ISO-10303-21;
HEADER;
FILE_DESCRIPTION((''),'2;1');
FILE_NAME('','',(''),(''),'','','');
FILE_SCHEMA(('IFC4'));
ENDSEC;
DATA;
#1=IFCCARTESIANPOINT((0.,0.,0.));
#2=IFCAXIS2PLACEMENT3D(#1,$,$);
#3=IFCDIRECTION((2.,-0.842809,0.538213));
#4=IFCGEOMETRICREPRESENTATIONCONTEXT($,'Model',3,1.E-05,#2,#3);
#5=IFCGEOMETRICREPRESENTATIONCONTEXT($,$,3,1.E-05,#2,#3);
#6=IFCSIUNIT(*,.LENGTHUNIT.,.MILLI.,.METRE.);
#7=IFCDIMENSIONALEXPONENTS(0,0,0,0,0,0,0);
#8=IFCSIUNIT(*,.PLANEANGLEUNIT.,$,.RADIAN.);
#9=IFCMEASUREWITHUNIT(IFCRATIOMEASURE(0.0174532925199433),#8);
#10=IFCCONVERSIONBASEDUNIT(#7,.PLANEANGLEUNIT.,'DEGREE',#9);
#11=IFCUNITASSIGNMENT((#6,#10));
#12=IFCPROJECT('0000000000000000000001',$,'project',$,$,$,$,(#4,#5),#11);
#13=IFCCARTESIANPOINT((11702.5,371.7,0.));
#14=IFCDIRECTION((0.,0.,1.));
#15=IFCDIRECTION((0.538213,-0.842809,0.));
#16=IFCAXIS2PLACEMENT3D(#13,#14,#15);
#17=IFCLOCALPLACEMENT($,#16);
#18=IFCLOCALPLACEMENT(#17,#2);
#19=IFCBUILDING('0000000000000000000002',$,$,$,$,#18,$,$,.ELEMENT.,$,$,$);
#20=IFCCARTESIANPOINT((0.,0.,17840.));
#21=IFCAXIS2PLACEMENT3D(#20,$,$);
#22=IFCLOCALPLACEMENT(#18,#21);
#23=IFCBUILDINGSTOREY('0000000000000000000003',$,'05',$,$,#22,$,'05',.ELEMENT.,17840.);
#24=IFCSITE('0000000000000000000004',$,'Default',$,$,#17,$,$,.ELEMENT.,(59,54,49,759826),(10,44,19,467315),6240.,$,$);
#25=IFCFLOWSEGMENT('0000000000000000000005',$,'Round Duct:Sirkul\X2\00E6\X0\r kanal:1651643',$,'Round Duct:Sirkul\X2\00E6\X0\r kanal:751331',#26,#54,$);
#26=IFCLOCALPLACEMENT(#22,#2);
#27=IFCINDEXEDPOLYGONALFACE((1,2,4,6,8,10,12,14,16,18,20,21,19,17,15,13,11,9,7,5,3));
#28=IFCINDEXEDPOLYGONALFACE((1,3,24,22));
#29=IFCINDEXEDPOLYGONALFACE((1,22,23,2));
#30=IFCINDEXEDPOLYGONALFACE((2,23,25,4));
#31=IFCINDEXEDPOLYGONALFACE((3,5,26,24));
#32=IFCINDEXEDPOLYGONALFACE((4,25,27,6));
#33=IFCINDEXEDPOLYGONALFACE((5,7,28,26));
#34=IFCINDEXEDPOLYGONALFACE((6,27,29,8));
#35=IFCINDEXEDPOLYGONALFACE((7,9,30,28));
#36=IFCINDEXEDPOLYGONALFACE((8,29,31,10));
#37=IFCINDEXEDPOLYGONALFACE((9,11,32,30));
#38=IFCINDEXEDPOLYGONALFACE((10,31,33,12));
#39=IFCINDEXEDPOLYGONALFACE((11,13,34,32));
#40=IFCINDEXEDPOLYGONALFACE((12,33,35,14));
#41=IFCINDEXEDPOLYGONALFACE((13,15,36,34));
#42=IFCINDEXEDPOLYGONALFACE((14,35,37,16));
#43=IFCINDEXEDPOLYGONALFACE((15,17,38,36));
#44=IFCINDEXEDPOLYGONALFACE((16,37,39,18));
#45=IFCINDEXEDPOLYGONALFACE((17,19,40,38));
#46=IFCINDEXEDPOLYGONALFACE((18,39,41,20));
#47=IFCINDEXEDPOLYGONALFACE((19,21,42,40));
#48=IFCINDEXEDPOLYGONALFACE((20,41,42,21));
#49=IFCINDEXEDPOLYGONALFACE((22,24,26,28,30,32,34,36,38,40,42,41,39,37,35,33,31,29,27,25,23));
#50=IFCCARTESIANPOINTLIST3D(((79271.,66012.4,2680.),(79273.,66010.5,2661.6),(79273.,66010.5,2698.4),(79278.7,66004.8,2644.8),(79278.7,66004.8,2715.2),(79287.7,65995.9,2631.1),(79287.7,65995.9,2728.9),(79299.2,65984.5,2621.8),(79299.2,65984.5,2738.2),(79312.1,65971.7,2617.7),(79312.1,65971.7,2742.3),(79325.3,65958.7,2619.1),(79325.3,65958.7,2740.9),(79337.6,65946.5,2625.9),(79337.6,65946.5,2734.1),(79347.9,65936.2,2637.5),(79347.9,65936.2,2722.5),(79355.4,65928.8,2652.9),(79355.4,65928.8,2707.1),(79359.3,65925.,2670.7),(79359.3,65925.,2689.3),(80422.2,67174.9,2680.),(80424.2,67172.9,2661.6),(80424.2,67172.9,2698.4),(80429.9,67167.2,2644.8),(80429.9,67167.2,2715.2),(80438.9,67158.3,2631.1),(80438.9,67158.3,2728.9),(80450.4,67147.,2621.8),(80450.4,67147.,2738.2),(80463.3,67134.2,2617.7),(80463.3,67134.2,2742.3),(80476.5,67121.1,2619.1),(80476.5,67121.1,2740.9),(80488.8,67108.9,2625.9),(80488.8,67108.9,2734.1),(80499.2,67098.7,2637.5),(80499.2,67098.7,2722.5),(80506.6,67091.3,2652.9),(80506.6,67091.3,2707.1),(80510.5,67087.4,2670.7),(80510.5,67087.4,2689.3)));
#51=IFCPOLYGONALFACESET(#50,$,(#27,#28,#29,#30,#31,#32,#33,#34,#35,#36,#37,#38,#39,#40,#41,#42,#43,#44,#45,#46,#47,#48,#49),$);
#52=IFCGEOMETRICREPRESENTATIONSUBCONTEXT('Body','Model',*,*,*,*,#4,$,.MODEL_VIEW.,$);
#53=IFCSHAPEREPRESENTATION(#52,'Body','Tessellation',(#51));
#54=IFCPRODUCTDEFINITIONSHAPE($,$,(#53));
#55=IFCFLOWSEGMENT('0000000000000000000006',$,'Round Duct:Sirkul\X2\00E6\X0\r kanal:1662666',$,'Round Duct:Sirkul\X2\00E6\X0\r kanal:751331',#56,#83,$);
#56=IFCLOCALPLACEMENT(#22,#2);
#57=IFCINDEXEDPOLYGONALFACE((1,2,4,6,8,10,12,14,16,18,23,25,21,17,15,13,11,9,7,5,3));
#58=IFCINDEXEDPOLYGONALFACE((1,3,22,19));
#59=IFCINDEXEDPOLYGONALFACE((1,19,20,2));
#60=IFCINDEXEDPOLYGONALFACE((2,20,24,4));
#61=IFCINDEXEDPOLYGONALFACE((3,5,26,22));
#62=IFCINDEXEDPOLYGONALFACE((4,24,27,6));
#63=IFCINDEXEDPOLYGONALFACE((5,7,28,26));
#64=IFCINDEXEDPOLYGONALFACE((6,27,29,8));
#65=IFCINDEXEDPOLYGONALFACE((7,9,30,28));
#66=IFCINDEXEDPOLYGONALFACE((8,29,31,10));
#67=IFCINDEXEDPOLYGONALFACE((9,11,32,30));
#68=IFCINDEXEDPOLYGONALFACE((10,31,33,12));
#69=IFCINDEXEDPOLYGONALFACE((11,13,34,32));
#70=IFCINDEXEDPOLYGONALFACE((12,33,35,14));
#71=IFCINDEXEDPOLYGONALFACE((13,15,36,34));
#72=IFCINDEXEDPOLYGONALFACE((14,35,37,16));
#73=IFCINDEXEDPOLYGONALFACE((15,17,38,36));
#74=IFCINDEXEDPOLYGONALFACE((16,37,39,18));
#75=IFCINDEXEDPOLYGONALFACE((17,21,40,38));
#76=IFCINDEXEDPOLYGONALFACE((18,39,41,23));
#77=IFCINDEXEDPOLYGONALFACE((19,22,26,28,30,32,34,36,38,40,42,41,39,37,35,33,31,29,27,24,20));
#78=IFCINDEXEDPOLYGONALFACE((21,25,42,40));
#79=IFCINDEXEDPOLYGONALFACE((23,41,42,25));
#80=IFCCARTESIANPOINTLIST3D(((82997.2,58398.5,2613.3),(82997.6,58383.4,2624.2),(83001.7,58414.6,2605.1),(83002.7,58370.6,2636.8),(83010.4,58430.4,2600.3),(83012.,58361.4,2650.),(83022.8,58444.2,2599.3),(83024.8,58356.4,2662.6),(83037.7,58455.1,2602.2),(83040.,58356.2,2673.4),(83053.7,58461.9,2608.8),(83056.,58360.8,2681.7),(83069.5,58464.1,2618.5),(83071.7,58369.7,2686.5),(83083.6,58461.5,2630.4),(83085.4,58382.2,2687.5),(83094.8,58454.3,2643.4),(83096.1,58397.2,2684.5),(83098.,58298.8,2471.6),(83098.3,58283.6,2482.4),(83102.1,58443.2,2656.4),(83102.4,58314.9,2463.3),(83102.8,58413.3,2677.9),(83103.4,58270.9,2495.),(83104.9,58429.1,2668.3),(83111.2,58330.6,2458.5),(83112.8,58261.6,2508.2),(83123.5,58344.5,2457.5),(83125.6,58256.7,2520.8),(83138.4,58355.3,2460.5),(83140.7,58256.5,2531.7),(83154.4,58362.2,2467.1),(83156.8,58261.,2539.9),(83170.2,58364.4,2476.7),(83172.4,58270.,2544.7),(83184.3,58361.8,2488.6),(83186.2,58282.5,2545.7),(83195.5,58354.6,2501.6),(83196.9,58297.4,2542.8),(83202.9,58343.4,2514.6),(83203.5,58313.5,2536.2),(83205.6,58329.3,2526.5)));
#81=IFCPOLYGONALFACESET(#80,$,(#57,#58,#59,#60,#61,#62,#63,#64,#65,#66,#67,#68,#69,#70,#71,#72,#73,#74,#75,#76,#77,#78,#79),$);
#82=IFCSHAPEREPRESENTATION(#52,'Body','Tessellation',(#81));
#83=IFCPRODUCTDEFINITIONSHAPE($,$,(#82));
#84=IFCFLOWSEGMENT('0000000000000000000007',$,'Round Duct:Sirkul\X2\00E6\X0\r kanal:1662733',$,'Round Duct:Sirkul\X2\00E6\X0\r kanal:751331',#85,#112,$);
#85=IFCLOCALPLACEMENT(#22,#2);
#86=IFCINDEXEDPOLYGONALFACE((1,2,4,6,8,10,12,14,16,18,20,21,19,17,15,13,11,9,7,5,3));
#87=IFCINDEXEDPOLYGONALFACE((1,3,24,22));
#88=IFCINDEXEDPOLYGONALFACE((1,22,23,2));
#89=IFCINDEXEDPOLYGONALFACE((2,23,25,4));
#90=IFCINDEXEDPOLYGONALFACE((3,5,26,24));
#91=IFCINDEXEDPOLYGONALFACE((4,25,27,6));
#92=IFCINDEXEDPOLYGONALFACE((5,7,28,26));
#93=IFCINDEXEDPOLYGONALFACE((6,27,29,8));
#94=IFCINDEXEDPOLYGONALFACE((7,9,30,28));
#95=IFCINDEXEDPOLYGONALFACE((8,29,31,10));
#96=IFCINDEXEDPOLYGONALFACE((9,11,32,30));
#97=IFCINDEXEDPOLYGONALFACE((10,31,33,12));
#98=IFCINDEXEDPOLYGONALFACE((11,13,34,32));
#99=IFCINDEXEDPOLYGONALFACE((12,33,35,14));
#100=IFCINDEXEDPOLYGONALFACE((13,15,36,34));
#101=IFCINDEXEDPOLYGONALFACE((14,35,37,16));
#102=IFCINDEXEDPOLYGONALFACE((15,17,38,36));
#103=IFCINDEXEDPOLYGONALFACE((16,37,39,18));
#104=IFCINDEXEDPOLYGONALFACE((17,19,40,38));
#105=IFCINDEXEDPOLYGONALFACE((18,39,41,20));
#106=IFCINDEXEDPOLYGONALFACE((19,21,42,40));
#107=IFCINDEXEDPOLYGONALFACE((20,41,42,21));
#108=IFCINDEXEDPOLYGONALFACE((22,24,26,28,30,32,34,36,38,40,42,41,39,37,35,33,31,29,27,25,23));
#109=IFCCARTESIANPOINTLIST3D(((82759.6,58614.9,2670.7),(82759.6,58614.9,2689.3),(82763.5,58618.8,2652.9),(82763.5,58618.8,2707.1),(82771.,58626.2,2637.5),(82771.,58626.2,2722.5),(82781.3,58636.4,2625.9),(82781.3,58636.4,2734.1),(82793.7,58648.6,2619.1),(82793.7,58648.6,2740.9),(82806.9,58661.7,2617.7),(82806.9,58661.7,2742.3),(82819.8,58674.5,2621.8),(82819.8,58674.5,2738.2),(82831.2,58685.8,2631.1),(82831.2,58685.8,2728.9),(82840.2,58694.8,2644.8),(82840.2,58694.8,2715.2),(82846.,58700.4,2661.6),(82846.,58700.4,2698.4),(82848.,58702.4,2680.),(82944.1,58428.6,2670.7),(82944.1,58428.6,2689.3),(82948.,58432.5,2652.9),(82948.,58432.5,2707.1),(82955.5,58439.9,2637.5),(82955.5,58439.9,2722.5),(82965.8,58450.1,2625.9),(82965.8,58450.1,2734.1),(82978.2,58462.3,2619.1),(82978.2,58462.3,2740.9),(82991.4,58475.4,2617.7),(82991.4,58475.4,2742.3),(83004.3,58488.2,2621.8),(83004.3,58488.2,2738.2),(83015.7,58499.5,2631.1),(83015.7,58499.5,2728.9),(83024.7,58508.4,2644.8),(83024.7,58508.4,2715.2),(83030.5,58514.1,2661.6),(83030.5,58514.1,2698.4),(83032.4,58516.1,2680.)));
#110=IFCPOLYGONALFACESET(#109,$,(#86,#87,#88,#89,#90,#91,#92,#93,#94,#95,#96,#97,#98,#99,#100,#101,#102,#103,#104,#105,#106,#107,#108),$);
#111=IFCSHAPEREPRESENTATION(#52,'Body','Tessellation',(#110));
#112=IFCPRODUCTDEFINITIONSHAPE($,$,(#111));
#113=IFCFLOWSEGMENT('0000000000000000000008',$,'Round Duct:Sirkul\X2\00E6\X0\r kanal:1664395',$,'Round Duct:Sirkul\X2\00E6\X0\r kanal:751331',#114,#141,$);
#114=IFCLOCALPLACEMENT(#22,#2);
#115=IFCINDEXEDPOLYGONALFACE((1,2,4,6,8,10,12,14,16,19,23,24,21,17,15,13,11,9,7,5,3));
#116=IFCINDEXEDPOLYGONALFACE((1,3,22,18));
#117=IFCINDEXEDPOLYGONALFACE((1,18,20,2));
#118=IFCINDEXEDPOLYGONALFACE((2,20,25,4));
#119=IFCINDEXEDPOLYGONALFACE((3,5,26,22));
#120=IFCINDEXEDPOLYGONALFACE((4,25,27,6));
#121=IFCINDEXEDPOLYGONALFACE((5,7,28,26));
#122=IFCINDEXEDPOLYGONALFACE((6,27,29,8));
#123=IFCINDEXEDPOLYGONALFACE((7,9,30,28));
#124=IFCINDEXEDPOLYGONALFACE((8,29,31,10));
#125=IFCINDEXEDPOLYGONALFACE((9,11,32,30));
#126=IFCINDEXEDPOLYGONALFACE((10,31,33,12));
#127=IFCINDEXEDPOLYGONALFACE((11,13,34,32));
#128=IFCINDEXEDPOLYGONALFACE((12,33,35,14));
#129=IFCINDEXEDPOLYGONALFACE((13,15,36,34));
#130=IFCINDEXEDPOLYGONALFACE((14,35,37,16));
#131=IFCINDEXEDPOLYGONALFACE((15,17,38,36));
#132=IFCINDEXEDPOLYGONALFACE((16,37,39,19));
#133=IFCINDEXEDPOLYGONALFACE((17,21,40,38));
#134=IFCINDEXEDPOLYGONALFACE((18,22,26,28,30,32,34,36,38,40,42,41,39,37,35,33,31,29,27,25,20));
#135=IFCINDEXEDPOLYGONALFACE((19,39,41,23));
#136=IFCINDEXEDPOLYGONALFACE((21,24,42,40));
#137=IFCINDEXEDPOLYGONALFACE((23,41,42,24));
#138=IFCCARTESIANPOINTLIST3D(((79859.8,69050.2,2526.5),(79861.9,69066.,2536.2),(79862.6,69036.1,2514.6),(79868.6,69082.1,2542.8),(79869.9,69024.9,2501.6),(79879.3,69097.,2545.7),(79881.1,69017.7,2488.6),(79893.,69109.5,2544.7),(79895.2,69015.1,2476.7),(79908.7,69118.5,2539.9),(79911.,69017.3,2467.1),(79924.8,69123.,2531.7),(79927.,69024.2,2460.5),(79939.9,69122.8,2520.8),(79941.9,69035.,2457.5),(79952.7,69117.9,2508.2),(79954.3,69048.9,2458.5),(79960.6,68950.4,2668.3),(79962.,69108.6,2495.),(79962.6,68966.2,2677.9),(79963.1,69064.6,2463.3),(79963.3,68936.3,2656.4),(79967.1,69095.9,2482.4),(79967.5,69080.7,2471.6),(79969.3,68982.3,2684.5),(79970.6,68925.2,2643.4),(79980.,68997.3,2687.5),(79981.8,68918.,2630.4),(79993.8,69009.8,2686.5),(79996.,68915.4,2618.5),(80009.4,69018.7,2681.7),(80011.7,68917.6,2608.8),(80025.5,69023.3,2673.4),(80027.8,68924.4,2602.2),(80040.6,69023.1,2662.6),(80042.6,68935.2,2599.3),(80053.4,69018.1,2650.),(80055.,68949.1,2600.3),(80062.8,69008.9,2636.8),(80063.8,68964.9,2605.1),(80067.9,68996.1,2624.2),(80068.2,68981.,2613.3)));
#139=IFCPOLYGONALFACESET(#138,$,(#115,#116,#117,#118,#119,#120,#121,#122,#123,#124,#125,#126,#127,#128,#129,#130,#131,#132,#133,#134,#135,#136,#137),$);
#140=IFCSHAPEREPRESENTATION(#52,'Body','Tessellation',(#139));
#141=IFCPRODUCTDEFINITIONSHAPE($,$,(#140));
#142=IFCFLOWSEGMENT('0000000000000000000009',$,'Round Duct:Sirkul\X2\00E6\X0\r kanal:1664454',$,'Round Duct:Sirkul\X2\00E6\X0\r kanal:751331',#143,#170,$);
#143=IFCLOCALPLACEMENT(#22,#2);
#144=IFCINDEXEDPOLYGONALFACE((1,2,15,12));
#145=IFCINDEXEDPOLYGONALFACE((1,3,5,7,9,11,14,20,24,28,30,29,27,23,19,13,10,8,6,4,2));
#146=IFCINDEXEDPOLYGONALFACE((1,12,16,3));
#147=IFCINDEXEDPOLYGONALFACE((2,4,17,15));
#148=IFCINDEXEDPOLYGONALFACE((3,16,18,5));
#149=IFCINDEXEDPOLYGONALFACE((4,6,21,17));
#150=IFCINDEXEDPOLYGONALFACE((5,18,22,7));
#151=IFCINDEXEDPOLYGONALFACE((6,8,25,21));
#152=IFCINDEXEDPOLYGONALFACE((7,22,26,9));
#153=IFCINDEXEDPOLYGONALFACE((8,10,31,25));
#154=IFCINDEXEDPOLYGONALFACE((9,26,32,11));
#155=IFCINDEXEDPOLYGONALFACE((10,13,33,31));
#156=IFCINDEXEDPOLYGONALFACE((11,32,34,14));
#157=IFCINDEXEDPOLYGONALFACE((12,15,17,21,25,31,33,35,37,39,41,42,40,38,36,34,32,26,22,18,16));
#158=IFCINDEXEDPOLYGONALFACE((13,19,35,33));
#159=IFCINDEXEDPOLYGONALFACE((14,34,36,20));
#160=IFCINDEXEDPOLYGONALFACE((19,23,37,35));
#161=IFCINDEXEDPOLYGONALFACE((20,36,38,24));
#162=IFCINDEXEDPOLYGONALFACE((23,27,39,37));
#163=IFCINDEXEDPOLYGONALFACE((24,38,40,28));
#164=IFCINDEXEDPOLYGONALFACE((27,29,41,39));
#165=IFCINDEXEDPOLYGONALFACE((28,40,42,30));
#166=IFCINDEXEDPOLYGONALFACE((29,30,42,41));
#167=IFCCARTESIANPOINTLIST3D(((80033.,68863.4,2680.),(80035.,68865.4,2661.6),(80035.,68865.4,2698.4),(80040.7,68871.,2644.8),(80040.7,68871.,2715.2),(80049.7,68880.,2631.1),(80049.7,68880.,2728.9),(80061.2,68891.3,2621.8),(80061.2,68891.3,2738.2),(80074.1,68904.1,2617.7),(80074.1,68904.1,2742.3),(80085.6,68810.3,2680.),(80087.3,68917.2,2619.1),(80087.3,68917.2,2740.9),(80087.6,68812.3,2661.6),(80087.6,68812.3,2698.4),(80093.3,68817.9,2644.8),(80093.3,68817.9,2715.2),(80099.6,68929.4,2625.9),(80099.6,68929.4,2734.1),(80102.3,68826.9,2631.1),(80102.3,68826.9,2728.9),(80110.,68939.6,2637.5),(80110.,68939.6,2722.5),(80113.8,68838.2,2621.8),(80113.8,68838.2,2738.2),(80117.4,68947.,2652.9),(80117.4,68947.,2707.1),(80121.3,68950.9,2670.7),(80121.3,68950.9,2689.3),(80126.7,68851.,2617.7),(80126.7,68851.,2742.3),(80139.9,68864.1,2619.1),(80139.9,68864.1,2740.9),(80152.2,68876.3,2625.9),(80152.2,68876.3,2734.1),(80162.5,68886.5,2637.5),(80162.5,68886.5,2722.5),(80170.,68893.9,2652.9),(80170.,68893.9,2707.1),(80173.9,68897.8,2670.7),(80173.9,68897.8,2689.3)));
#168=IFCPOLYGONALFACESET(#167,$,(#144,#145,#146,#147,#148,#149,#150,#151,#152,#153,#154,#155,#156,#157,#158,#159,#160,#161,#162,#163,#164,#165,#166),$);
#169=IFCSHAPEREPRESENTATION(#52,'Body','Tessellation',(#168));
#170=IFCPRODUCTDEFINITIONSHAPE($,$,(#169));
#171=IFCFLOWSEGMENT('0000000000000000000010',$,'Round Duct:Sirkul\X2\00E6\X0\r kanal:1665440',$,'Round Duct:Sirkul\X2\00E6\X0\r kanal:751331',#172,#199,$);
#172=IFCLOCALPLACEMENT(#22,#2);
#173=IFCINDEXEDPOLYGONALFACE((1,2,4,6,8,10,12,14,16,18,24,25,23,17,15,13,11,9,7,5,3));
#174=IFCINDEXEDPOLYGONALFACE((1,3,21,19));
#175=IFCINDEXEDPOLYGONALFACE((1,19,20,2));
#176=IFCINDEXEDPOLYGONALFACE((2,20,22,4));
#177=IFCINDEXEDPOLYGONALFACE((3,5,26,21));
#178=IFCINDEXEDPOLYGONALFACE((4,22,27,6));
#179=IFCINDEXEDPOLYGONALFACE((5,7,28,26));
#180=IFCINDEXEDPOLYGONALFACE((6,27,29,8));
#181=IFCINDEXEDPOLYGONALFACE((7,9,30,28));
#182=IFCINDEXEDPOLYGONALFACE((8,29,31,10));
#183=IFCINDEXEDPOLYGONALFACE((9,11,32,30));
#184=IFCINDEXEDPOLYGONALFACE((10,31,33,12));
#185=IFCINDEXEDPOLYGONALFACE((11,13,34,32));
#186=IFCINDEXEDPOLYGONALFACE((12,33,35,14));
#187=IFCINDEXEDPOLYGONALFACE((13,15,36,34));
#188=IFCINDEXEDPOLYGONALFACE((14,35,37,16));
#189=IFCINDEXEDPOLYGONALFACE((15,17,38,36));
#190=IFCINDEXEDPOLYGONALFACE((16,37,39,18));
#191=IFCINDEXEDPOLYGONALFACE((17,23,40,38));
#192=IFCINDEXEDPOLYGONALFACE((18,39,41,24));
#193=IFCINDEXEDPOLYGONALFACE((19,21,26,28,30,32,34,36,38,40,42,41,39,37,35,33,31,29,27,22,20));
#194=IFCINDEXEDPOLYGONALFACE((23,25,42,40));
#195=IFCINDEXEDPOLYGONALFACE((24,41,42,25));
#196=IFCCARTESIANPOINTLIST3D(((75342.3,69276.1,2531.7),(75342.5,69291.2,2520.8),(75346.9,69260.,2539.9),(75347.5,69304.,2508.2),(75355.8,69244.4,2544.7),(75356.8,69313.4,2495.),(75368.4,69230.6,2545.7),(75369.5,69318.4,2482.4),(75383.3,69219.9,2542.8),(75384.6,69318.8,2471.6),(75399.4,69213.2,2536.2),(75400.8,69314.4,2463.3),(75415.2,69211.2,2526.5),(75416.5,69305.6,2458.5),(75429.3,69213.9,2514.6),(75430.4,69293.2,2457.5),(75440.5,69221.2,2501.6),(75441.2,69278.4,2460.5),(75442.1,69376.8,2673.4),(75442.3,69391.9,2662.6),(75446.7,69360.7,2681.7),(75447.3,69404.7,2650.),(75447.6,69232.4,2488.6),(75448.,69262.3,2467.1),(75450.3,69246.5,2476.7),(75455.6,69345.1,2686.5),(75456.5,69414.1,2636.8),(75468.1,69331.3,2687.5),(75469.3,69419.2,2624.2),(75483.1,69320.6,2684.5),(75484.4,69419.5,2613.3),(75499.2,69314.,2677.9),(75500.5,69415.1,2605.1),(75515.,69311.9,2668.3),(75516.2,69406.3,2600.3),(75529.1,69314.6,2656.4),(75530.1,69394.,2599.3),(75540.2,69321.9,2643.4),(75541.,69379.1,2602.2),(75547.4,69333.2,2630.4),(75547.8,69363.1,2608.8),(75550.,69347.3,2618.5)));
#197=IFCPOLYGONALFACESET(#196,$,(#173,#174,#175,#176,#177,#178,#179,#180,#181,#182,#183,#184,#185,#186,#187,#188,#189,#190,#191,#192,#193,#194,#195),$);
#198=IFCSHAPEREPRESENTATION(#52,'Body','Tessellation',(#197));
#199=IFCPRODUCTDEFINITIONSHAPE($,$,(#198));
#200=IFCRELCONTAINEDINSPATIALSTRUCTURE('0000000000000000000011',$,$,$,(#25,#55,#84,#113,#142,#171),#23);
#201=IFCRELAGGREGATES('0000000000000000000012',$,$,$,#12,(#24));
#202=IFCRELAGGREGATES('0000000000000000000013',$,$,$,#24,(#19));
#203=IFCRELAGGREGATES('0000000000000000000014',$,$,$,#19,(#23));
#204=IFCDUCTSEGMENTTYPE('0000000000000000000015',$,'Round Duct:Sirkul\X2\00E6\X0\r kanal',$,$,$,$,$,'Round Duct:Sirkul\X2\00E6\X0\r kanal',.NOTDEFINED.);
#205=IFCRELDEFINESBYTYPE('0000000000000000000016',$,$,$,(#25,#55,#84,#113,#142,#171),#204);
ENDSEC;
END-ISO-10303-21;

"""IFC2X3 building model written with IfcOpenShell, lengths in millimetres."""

from ifc_helpers import new_model, entity, si_unit, converted_unit, direction, frame, frame_2d, origin, origin_2d_with_axis, place, context, subcontext, project, spatial, circle, extrude, type_object, element, save


model = new_model("IFC2X3")

# Units and contexts
model_context = context("Model", 3, precision=1e-05, world=origin(), true_north=direction((2.0, -0.842809, 0.538213)))
context_of_model = context(None, 3, precision=1e-05, world=origin(), true_north=direction((2.0, -0.842809, 0.538213)))
body_context = subcontext(model_context, "Body", "Model", "MODEL_VIEW")
ifc_project = project(units=[si_unit("LENGTHUNIT", "METRE", prefix="MILLI"), converted_unit("PLANEANGLEUNIT", "DEGREE", entity("IfcRatioMeasure", 0.0174532925199433), si_unit("PLANEANGLEUNIT", "RADIAN"), dimensions=[0, 0, 0, 0, 0, 0, 0])], contexts=[model_context, context_of_model])

# Site, building, storey
site_placement = place(None, frame((11702.5, 371.7, 0.0), z_axis=(0.0, 0.0, 1.0), x_axis=(0.538213, -0.842809, 0.0)))
site = spatial("IfcSite", under=ifc_project, at=site_placement, Name="Default", CompositionType="ELEMENT", RefLatitude=(59, 54, 49, 759826), RefLongitude=(10, 44, 19, 467315), RefElevation=6240.0)
building_placement = place(site_placement, origin())
building = spatial("IfcBuilding", under=site, at=building_placement, CompositionType="ELEMENT")
storey_placement = place(building_placement, frame((0.0, 0.0, 17840.0)))
storey = spatial("IfcBuildingStorey", under=building, at=storey_placement, Name="05", LongName="05", CompositionType="ELEMENT", Elevation=17840.0)

# Flow segments
duct_segment_type = type_object("IfcDuctSegmentType", Name="Round Duct:Sirkulær kanal", ElementType="Round Duct:Sirkulær kanal", PredefinedType="NOTDEFINED")
flow_segment_1_placement = place(storey_placement, origin())
element("IfcFlowSegment", 1, at=flow_segment_1_placement, inside=storey, type_object=duct_segment_type, Name="Round Duct:Sirkulær kanal:1651643", ObjectType="Round Duct:Sirkulær kanal:751331", context=body_context, shape_type="SweptSolid", body=[
    extrude(circle(Radius=62.5, at=origin_2d_with_axis()), frame((79315.4, 65968.5, 2680.0), z_axis=(0.703669, 0.710528, 0.0), x_axis=(-0.710528, 0.703669, 0.0)), (0.0, 0.0, 1.0), 1636.0),
])
flow_segment_2_placement = place(storey_placement, origin())
element("IfcFlowSegment", 2, at=flow_segment_2_placement, inside=storey, type_object=duct_segment_type, Name="Round Duct:Sirkulær kanal:1662666", ObjectType="Round Duct:Sirkulær kanal:751331", context=body_context, shape_type="SweptSolid", body=[
    extrude(circle(Radius=62.5, at=origin_2d_with_axis()), frame((83151.6, 58310.2, 2501.6), z_axis=(-0.502419, 0.497569, 0.707107), x_axis=(0.703669, 0.710528, 0.0)), (0.0, 0.0, 1.0), 200.5),
])
flow_segment_3_placement = place(storey_placement, origin())
element("IfcFlowSegment", 3, at=flow_segment_3_placement, inside=storey, type_object=duct_segment_type, Name="Round Duct:Sirkulær kanal:1662733", ObjectType="Round Duct:Sirkulær kanal:751331", context=body_context, shape_type="SweptSolid", body=[
    extrude(circle(Radius=62.5, at=origin_2d_with_axis()), frame((82803.5, 58658.4, 2680.0), z_axis=(0.703643, -0.710554, 0.0), x_axis=(0.710554, 0.703643, 0.0)), (0.0, 0.0, 1.0), 262.2),
])
flow_segment_4_placement = place(storey_placement, origin())
element("IfcFlowSegment", 4, at=flow_segment_4_placement, inside=storey, type_object=duct_segment_type, Name="Round Duct:Sirkulær kanal:1664395", ObjectType="Round Duct:Sirkulær kanal:751331", context=body_context, shape_type="SweptSolid", body=[
    extrude(circle(Radius=62.5, at=frame_2d((0.0, 0.0), x_axis=(1.0, 0.0))), frame((79913.9, 69069.3, 2501.6), z_axis=(0.502419, -0.497569, 0.707107), x_axis=(-0.703669, -0.710528, 0.0)), (0.0, 0.0, 1.0), 200.5),
])
flow_segment_5_placement = place(storey_placement, origin())
element("IfcFlowSegment", 5, at=flow_segment_5_placement, inside=storey, type_object=duct_segment_type, Name="Round Duct:Sirkulær kanal:1664454", ObjectType="Round Duct:Sirkulær kanal:751331", context=body_context, shape_type="SweptSolid", body=[
    extrude(circle(Radius=62.5, at=origin_2d_with_axis()), frame((80077.4, 68907.4, 2680.0), z_axis=(0.703643, -0.710554, 0.0), x_axis=(-0.710554, -0.703643, 0.0)), (0.0, 0.0, 1.0), 74.7),
])
flow_segment_6_placement = place(storey_placement, origin())
element("IfcFlowSegment", 6, at=flow_segment_6_placement, inside=storey, type_object=duct_segment_type, Name="Round Duct:Sirkulær kanal:1665440", ObjectType="Round Duct:Sirkulær kanal:751331", context=body_context, shape_type="SweptSolid", body=[
    extrude(circle(Radius=62.5, at=origin_2d_with_axis()), frame((75396.0, 69265.2, 2501.6), z_axis=(0.497569, 0.502419, 0.707107), x_axis=(0.710528, -0.703669, 0.0)), (0.0, 0.0, 1.0), 200.5),
])

save(model, "model.ifc")
